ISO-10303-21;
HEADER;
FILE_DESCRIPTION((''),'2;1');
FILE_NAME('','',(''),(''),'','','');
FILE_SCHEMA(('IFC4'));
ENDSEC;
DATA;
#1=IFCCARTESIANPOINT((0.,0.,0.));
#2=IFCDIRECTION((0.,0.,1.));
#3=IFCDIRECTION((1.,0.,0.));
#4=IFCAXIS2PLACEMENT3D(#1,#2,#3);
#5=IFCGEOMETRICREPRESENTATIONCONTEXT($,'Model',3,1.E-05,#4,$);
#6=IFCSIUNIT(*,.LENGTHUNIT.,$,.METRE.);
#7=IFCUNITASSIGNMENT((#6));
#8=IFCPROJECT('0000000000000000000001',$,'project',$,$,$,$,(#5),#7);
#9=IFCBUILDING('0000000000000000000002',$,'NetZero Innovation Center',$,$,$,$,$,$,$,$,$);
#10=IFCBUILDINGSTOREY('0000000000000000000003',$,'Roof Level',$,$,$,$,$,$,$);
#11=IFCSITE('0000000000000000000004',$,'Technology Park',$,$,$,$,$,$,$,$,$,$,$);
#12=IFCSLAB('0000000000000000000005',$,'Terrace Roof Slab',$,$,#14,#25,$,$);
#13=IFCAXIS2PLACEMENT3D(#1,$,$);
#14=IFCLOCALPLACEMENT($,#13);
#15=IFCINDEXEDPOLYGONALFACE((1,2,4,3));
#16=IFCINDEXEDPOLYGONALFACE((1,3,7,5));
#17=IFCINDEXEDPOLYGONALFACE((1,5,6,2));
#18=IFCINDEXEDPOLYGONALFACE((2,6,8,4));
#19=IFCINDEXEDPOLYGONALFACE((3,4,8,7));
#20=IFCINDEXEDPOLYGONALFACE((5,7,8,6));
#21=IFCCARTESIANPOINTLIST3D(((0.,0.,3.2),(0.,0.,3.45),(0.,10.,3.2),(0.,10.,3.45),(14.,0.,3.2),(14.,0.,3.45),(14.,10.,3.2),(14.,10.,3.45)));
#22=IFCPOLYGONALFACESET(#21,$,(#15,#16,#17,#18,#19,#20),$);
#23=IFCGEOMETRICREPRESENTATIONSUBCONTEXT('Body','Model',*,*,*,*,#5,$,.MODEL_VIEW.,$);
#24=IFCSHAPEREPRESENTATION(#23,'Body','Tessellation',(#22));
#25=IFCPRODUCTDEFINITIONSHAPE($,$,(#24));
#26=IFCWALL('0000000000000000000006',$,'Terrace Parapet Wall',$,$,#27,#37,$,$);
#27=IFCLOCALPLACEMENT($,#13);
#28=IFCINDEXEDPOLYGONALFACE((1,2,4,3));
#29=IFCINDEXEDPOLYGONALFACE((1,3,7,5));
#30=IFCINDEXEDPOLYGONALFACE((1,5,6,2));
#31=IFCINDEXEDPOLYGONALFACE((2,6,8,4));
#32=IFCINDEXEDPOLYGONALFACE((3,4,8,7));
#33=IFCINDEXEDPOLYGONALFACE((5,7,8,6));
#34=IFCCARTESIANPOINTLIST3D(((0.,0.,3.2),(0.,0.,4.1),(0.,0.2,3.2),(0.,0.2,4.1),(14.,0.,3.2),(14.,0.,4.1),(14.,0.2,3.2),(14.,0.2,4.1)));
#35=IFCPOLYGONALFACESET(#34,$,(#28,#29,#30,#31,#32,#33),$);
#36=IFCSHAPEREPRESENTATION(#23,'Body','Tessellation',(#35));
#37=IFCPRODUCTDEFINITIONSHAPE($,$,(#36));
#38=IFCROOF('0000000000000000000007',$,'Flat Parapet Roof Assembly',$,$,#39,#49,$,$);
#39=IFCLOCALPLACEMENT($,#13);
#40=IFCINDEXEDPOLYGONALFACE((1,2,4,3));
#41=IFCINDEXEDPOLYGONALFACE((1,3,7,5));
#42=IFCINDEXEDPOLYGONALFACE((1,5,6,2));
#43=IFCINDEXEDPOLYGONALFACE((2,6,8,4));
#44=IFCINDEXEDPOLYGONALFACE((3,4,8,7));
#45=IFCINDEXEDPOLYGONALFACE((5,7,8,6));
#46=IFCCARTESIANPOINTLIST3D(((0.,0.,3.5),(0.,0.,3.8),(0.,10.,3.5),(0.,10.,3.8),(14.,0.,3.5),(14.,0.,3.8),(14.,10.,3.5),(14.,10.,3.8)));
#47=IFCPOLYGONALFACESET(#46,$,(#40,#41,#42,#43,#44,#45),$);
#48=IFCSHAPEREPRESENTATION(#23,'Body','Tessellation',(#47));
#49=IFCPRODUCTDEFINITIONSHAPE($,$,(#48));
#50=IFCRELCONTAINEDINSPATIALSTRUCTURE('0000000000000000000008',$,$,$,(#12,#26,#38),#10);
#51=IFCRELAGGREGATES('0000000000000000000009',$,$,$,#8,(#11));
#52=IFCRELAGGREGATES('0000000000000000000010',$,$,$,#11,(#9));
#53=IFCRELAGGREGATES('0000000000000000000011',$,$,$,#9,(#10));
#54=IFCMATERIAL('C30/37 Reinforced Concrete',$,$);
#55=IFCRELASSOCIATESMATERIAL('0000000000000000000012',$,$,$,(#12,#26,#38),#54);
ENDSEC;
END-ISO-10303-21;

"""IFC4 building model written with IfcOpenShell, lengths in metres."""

from ifc_helpers import new_model, si_unit, frame, origin_with_axes, place, context, subcontext, project, spatial, indexed_curve, outline, extrude, material, element, save


model = new_model("IFC4")

# Units and contexts
model_context = context("Model", 3, precision=1e-05, world=origin_with_axes())
body_context = subcontext(model_context, "Body", "Model", "MODEL_VIEW")
ifc_project = project(units=[si_unit("LENGTHUNIT", "METRE")], contexts=[model_context])

# Site, building, storey
site = spatial("IfcSite", under=ifc_project, Name="Technology Park")
building = spatial("IfcBuilding", under=site, Name="NetZero Innovation Center")
storey = spatial("IfcBuildingStorey", under=building, Name="Roof Level")

# Slab
ifc_material = material(Name="C30/37 Reinforced Concrete")
slab_placement = place(None, frame((0.0, 0.0, 3.2), z_axis=(0.0, 0.0, 1.0), x_axis=(1.0, 0.0, 0.0)))
element("IfcSlab", 1, at=slab_placement, inside=storey, material=ifc_material, Name="Terrace Roof Slab", context=body_context, shape_type="SweptSolid", body=[
    extrude(outline(indexed_curve([(0.0, 0.0), (14.0, 0.0), (14.0, 10.0), (0.0, 10.0), (0.0, 0.0)])), None, (0.0, 0.0, 1.0), 0.25),
])

# Wall
wall_placement = place(None, frame((0.0, 0.0, 3.2), z_axis=(0.0, 0.0, 1.0), x_axis=(1.0, 0.0, 0.0)))
element("IfcWall", 2, at=wall_placement, inside=storey, material=ifc_material, Name="Terrace Parapet Wall", context=body_context, shape_type="SweptSolid", body=[
    extrude(outline(indexed_curve([(0.0, 0.0), (0.0, 0.2), (14.0, 0.2), (14.0, 0.0), (0.0, 0.0)], self_intersect=False)), origin_with_axes(), (0.0, 0.0, 1.0), 0.9),
])

# Roof
roof_placement = place(None, frame((0.0, 0.0, 3.5), z_axis=(0.0, 0.0, 1.0), x_axis=(1.0, 0.0, 0.0)))
element("IfcRoof", 3, at=roof_placement, inside=storey, material=ifc_material, Name="Flat Parapet Roof Assembly", context=body_context, shape_type="SweptSolid", body=[
    extrude(outline(indexed_curve([(0.0, 0.0), (14.0, 0.0), (14.0, 10.0), (0.0, 10.0), (0.0, 0.0)])), origin_with_axes(), (0.0, 0.0, 1.0), 0.3),
])

save(model, "model.ifc")
